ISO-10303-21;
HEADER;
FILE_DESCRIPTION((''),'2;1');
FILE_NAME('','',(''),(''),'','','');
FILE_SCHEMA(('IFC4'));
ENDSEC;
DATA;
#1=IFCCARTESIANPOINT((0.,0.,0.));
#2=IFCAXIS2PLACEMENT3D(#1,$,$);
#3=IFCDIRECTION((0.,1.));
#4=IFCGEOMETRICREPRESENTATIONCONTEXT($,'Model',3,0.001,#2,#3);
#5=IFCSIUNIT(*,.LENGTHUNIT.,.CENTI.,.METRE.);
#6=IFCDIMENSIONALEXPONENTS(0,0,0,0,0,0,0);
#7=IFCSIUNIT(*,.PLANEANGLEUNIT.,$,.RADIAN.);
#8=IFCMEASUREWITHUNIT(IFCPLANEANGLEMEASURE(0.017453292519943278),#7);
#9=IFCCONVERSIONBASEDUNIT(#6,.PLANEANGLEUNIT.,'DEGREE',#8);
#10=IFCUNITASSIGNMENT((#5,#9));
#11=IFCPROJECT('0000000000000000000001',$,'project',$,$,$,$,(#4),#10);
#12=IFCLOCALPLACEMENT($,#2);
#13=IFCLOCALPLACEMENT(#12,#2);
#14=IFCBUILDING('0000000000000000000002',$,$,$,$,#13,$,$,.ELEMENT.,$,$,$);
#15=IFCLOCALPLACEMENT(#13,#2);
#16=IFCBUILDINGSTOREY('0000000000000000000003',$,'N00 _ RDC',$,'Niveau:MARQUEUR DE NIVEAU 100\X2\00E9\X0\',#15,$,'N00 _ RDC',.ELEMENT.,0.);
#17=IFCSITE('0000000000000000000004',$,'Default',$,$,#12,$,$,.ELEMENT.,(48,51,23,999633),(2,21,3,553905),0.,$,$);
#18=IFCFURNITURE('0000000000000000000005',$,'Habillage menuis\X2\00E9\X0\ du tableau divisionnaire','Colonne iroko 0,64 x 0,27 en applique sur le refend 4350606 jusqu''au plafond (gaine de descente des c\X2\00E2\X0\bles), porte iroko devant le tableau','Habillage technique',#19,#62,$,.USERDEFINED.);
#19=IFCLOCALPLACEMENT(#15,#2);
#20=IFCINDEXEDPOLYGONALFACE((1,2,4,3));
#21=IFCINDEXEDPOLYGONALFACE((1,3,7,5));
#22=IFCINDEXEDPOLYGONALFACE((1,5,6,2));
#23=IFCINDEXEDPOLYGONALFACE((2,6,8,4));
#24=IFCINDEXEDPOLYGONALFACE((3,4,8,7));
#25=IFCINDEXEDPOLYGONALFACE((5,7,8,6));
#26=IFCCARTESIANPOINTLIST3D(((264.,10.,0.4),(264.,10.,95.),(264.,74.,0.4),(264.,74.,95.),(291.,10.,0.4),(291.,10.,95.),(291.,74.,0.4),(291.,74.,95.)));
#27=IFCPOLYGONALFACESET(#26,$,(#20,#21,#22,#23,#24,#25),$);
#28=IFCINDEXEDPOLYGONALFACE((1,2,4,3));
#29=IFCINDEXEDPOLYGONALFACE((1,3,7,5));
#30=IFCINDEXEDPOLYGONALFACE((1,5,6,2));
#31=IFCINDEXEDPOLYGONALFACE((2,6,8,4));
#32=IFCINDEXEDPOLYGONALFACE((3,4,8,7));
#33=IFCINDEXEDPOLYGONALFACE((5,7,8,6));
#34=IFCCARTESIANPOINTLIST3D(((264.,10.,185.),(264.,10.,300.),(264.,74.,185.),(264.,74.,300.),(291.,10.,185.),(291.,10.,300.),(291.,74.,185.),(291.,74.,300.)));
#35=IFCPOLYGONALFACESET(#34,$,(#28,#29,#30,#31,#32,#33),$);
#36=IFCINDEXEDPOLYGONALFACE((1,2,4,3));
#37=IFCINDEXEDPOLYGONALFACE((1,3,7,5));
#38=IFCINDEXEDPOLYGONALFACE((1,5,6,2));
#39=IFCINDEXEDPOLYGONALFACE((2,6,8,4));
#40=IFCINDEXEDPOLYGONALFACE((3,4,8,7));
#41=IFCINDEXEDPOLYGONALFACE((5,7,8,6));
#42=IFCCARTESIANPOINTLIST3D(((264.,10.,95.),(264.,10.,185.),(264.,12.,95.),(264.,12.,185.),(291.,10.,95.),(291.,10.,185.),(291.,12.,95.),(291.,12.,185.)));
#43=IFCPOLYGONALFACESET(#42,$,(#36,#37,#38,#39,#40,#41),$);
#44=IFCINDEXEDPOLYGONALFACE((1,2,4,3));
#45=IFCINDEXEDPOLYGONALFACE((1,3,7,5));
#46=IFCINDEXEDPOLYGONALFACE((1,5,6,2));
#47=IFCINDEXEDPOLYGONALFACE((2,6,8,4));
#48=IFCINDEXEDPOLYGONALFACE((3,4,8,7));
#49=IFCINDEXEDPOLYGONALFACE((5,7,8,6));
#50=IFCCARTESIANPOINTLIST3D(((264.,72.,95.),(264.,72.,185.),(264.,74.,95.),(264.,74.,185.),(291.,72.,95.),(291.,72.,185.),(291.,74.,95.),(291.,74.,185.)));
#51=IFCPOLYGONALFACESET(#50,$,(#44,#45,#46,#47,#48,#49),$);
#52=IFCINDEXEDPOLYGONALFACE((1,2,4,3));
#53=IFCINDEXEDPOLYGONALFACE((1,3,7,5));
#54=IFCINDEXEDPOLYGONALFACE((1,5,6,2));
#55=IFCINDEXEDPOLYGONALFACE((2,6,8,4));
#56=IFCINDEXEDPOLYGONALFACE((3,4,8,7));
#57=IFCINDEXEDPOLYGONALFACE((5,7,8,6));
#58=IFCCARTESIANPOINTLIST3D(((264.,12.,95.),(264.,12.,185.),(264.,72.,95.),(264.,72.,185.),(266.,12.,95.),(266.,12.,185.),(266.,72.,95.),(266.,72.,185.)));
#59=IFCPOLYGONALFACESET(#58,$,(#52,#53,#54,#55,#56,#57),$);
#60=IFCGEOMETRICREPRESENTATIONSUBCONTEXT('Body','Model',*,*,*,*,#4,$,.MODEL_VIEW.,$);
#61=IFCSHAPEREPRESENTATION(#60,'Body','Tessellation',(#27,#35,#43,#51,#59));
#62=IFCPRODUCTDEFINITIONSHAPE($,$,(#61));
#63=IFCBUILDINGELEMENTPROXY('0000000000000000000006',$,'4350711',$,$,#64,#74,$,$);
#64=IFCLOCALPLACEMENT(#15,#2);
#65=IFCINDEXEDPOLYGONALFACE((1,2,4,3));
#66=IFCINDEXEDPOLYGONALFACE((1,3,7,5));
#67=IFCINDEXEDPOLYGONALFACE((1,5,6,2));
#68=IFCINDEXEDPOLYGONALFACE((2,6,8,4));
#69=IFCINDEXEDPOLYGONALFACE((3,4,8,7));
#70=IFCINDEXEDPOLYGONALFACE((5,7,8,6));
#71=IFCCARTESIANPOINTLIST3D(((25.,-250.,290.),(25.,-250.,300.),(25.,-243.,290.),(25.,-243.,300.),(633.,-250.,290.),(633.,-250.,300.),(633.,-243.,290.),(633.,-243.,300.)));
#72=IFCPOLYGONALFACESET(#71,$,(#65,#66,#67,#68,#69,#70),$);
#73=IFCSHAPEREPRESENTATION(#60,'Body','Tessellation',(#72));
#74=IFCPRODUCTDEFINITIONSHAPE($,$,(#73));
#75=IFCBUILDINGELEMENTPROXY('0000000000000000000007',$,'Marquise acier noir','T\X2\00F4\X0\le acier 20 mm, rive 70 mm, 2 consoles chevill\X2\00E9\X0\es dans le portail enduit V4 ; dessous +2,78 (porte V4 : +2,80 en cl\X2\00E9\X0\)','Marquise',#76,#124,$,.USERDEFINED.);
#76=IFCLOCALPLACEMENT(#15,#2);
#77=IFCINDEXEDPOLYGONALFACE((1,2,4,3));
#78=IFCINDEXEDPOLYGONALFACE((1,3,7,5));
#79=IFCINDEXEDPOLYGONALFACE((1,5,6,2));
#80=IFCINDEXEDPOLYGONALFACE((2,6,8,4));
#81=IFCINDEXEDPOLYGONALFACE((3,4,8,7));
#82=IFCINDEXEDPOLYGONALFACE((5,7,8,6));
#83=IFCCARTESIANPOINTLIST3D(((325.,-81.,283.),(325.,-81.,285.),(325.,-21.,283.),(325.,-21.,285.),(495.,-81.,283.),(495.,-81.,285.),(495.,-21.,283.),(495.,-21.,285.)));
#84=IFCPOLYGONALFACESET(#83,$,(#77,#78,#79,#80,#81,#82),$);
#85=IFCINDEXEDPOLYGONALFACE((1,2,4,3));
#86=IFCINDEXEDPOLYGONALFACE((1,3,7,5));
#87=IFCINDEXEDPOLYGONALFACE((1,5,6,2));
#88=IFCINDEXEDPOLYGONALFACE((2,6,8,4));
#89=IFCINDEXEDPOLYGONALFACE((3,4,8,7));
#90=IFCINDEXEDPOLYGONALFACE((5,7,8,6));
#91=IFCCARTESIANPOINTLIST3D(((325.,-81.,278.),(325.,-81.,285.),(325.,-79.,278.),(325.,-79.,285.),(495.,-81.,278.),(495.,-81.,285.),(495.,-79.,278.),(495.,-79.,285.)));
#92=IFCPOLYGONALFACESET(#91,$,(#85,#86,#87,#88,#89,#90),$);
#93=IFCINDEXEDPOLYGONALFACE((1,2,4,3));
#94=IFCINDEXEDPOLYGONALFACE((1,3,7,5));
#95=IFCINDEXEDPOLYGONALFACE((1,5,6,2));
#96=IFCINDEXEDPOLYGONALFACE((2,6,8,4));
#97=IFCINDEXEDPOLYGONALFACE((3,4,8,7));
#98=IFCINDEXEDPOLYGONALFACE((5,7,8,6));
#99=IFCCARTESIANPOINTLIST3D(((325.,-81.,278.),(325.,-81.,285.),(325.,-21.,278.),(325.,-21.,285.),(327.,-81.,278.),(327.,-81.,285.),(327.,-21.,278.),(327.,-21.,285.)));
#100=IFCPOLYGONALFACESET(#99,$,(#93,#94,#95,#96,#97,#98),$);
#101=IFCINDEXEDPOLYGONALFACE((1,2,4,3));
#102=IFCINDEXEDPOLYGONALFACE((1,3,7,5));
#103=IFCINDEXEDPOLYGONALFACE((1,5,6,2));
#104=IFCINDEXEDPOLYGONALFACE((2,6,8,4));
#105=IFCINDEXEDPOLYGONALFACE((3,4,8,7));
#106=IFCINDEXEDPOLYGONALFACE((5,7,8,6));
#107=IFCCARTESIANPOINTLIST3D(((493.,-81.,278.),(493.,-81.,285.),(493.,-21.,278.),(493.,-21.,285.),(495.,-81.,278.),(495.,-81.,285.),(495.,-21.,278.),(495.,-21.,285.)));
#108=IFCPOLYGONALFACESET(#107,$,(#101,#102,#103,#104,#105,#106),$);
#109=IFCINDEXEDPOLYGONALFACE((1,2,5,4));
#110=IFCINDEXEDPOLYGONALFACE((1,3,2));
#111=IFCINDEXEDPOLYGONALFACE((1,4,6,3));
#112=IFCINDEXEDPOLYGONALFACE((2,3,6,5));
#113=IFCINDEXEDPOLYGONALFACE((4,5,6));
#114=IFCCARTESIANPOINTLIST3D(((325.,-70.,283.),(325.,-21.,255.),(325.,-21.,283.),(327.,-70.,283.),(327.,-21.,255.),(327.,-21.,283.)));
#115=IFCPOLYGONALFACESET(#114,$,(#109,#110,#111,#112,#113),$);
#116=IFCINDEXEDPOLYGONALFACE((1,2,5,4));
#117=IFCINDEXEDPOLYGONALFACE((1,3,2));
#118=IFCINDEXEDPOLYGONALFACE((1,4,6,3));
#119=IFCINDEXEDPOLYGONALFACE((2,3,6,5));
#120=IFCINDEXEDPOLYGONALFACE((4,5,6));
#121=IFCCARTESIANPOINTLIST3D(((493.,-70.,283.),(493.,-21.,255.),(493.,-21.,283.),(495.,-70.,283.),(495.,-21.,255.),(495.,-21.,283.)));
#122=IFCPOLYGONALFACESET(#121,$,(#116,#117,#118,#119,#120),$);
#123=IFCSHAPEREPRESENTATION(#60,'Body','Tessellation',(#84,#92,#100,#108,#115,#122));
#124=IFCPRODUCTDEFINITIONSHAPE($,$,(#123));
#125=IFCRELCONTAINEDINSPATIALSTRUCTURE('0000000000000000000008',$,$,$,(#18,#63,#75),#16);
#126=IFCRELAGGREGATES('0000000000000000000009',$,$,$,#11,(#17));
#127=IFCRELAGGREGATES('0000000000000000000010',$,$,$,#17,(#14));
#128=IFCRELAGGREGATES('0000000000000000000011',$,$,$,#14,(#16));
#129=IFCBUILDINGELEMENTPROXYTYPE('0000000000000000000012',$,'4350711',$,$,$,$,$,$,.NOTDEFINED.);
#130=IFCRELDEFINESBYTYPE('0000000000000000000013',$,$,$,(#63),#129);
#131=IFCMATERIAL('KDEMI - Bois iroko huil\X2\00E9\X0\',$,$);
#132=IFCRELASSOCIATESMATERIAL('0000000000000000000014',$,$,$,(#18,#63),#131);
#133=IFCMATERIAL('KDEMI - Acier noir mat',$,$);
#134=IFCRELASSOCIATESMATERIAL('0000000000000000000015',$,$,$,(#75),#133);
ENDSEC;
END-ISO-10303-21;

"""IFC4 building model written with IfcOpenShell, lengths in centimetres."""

from ifc_helpers import new_model, entity, si_unit, converted_unit, direction, frame, frame_2d, origin, origin_with_axes, place, context, subcontext, project, spatial, polyline, rectangle, outline, extrude, material, type_object, element, save


model = new_model("IFC4")

# Units and contexts
model_context = context("Model", 3, precision=0.001, world=origin(), true_north=direction((0.0, 1.0)))
body_context = subcontext(model_context, "Body", "Model", "MODEL_VIEW")
ifc_project = project(units=[si_unit("LENGTHUNIT", "METRE", prefix="CENTI"), converted_unit("PLANEANGLEUNIT", "DEGREE", entity("IfcPlaneAngleMeasure", 0.017453292519943278), si_unit("PLANEANGLEUNIT", "RADIAN"), dimensions=[0, 0, 0, 0, 0, 0, 0])], contexts=[model_context])

# Site, building, storey
site_placement = place(None, origin())
site = spatial("IfcSite", under=ifc_project, at=site_placement, Name="Default", CompositionType="ELEMENT", RefLatitude=(48, 51, 23, 999633), RefLongitude=(2, 21, 3, 553905), RefElevation=0.0)
building_placement = place(site_placement, origin())
building = spatial("IfcBuilding", under=site, at=building_placement, CompositionType="ELEMENT")
storey_placement = place(building_placement, origin())
storey = spatial("IfcBuildingStorey", under=building, at=storey_placement, Name="N00 _ RDC", ObjectType="Niveau:MARQUEUR DE NIVEAU 100é", LongName="N00 _ RDC", CompositionType="ELEMENT", Elevation=0.0)

# Furniture
ifc_material_1 = material(Name="KDEMI - Bois iroko huilé")
furniture_1_placement = place(storey_placement, origin_with_axes())
element("IfcFurniture", 1, at=furniture_1_placement, inside=storey, material=ifc_material_1, Name="Habillage menuisé du tableau divisionnaire", Description="Colonne iroko 0,64 x 0,27 en applique sur le refend 4350606 jusqu'au plafond (gaine de descente des câbles), porte iroko devant le tableau", ObjectType="Habillage technique", PredefinedType="USERDEFINED", context=body_context, shape_type="SweptSolid", body=[
    extrude(rectangle(XDim=27.0, YDim=64.0, at=frame_2d((277.5, 42.0))), frame((0.0, 0.0, 0.4)), (0.0, 0.0, 1.0), 94.6),
    extrude(rectangle(XDim=27.0, YDim=64.0, at=frame_2d((277.5, 42.0))), frame((0.0, 0.0, 185.0)), (0.0, 0.0, 1.0), 115.0),
    extrude(rectangle(XDim=27.0, YDim=2.0, at=frame_2d((277.5, 11.0))), frame((0.0, 0.0, 95.0)), (0.0, 0.0, 1.0), 90.0),
    extrude(rectangle(XDim=27.0, YDim=2.0, at=frame_2d((277.5, 73.0))), frame((0.0, 0.0, 95.0)), (0.0, 0.0, 1.0), 90.0),
    extrude(rectangle(XDim=2.0, YDim=60.0, at=frame_2d((265.0, 42.0))), frame((0.0, 0.0, 95.0)), (0.0, 0.0, 1.0), 90.0),
])

# Building element proxies
building_element_proxy_type_1 = type_object("IfcBuildingElementProxyType", Name="4350711", PredefinedType="NOTDEFINED")
proxy_1_placement = place(storey_placement, frame((0.0, 0.0, 25.0), z_axis=(0.0, 0.0, 1.0), x_axis=(1.0, 0.0, 0.0)))
element("IfcBuildingElementProxy", 2, at=proxy_1_placement, inside=storey, type_object=building_element_proxy_type_1, material=ifc_material_1, Name="4350711", context=body_context, shape_type="SweptSolid", body=[
    extrude(rectangle(XDim=608.0, YDim=7.0, at=frame_2d((0.0, 0.0), x_axis=(1.0, 0.0))), frame((329.0, -246.5, 265.0)), (0.0, 0.0, 1.0), 10.0),
])
ifc_material_2 = material(Name="KDEMI - Acier noir mat")
proxy_2_placement = place(storey_placement, origin_with_axes())
element("IfcBuildingElementProxy", 3, at=proxy_2_placement, inside=storey, material=ifc_material_2, Name="Marquise acier noir", Description="Tôle acier 20 mm, rive 70 mm, 2 consoles chevillées dans le portail enduit V4 ; dessous +2,78 (porte V4 : +2,80 en clé)", ObjectType="Marquise", PredefinedType="USERDEFINED", context=body_context, shape_type="SweptSolid", body=[
    extrude(rectangle(XDim=170.0, YDim=60.0, at=frame_2d((410.0, -51.0))), frame((0.0, 0.0, 283.0)), (0.0, 0.0, 1.0), 2.0),
    extrude(rectangle(XDim=170.0, YDim=2.0, at=frame_2d((410.0, -80.0))), frame((0.0, 0.0, 278.0)), (0.0, 0.0, 1.0), 7.0),
    extrude(rectangle(XDim=2.0, YDim=60.0, at=frame_2d((326.0, -51.0))), frame((0.0, 0.0, 278.0)), (0.0, 0.0, 1.0), 7.0),
    extrude(rectangle(XDim=2.0, YDim=60.0, at=frame_2d((494.0, -51.0))), frame((0.0, 0.0, 278.0)), (0.0, 0.0, 1.0), 7.0),
    extrude(outline(polyline([(-21.0, 255.0), (-70.0, 283.0), (-21.0, 283.0), (-21.0, 255.0)])), frame((325.0, 0.0, 0.0), z_axis=(1.0, 0.0, 0.0), x_axis=(0.0, 1.0, 0.0)), (0.0, 0.0, 1.0), 2.0),
    extrude(outline(polyline([(-21.0, 255.0), (-70.0, 283.0), (-21.0, 283.0), (-21.0, 255.0)])), frame((493.0, 0.0, 0.0), z_axis=(1.0, 0.0, 0.0), x_axis=(0.0, 1.0, 0.0)), (0.0, 0.0, 1.0), 2.0),
])

save(model, "model.ifc")
